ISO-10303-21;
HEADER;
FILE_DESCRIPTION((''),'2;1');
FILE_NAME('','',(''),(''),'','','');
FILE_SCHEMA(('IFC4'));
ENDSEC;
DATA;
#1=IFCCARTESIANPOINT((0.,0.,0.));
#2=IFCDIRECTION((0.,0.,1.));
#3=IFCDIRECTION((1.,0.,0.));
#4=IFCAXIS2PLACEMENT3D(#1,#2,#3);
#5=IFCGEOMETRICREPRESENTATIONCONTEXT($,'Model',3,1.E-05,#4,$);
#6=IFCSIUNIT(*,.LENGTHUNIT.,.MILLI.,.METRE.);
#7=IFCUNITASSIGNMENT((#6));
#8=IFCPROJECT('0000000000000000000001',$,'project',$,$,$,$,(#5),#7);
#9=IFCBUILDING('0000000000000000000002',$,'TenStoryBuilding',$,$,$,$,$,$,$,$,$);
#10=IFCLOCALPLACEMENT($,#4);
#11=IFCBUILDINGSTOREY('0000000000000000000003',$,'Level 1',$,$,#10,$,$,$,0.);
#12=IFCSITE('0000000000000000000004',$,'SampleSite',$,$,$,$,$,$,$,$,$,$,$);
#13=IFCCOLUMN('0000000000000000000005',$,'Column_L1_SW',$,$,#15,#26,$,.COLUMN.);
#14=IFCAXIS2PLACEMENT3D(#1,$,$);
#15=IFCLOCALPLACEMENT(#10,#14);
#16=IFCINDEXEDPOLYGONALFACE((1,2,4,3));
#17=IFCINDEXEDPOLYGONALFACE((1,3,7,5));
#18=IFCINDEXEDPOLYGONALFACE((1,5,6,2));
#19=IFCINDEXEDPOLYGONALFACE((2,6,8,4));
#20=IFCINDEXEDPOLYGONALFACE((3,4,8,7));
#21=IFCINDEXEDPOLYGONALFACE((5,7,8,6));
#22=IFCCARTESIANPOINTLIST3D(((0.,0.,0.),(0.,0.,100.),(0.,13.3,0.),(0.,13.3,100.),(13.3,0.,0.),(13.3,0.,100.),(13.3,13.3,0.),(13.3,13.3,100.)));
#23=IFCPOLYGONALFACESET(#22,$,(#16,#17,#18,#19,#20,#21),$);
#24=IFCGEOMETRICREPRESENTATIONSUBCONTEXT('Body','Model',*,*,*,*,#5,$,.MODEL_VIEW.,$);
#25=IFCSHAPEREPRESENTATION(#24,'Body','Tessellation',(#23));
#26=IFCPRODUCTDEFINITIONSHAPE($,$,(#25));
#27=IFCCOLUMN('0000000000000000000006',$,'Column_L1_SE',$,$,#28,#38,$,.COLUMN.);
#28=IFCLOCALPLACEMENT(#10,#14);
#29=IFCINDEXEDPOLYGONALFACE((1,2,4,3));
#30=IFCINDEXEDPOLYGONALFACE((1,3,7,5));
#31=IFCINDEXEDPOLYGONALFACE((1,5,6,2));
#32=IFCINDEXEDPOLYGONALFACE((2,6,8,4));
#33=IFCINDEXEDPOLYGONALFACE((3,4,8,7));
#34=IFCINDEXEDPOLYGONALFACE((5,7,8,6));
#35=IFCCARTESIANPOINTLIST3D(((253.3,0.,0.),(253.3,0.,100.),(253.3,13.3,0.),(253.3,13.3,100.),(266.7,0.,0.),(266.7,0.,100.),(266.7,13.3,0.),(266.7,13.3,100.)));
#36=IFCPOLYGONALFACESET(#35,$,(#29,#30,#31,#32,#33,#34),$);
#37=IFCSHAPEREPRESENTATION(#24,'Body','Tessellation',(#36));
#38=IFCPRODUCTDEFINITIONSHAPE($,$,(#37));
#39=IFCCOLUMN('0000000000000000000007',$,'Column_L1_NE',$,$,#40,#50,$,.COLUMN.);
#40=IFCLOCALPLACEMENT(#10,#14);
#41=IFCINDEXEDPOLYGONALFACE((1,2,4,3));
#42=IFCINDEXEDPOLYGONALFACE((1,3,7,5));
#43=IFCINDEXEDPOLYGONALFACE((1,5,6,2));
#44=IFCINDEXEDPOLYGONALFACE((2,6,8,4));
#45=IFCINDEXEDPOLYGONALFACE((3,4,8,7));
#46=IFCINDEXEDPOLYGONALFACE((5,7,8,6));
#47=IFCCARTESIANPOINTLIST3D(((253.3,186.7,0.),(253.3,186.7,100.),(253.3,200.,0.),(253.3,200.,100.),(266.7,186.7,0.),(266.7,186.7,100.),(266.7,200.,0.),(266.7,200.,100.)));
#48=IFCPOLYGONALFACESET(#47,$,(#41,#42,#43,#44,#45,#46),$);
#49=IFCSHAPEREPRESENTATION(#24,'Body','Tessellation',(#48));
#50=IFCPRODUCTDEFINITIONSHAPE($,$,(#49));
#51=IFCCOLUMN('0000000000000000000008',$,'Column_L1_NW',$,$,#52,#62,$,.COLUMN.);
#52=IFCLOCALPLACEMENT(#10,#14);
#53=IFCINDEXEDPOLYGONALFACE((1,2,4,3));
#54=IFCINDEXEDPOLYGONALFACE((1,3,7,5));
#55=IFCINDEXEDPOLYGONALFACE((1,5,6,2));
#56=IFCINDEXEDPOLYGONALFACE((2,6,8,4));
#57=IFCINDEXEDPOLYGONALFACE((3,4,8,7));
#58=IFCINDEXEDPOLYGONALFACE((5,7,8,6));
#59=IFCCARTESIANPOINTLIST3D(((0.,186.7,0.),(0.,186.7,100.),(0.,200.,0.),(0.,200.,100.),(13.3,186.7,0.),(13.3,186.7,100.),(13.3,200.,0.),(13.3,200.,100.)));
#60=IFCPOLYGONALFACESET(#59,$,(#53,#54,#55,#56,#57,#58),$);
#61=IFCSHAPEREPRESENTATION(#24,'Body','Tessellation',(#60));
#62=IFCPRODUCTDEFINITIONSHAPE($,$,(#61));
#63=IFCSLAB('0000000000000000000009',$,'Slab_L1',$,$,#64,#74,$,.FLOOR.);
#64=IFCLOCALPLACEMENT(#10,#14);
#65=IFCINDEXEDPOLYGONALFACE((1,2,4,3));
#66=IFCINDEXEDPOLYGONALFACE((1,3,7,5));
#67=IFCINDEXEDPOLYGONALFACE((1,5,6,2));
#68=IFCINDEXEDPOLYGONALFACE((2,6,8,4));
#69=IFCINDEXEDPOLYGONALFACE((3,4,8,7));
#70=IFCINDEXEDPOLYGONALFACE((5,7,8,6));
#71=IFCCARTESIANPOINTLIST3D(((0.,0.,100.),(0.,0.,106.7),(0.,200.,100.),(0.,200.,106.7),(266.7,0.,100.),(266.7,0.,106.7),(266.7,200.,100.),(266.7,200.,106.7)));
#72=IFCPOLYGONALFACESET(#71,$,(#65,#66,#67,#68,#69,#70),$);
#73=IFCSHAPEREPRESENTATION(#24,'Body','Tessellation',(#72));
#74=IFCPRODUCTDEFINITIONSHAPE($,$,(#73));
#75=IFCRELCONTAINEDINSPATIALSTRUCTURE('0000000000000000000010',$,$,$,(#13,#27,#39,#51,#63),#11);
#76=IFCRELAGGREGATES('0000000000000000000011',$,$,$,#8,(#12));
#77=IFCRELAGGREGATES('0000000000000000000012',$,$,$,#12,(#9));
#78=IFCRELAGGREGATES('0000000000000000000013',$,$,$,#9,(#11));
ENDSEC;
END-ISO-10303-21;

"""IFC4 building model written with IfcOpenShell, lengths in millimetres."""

from ifc_helpers import new_model, si_unit, frame, origin_with_axes, origin_2d, place, context, subcontext, project, spatial, indexed_curve, rectangle, outline, extrude, element, save


model = new_model("IFC4")

# Units and contexts
model_context = context("Model", 3, precision=1e-05, world=origin_with_axes())
body_context = subcontext(model_context, "Body", "Model", "MODEL_VIEW")
ifc_project = project(units=[si_unit("LENGTHUNIT", "METRE", prefix="MILLI")], contexts=[model_context])

# Site, building, storey
site = spatial("IfcSite", under=ifc_project, Name="SampleSite")
building = spatial("IfcBuilding", under=site, Name="TenStoryBuilding")
storey_placement = place(None, origin_with_axes())
storey = spatial("IfcBuildingStorey", under=building, at=storey_placement, Name="Level 1", Elevation=0.0)

# Columns
for number, where, z_axis, x_axis, name in (
    (1, (6.7, 6.7, 0.0), (0.0, 0.0, 1.0), (1.0, 0.0, 0.0), "Column_L1_SW"),
    (2, (260.0, 6.7, 0.0), (0.0, 0.0, 1.0), (1.0, 0.0, 0.0), "Column_L1_SE"),
    (3, (260.0, 193.3, 0.0), (0.0, 0.0, 1.0), (1.0, 0.0, 0.0), "Column_L1_NE"),
    (4, (6.7, 193.3, 0.0), (0.0, 0.0, 1.0), (1.0, 0.0, 0.0), "Column_L1_NW"),
):
    element("IfcColumn", number, at=place(storey_placement, frame(where, z_axis=z_axis, x_axis=x_axis)), inside=storey, Name=name, PredefinedType="COLUMN", context=body_context, shape_type="SweptSolid", body=[
        extrude(rectangle(XDim=13.3, YDim=13.3, at=origin_2d()), origin_with_axes(), (0.0, 0.0, 1.0), 100.0),
    ])

# Slab
slab_placement = place(storey_placement, frame((0.0, 0.0, 100.0), z_axis=(0.0, 0.0, 1.0), x_axis=(1.0, 0.0, 0.0)))
element("IfcSlab", 5, at=slab_placement, inside=storey, Name="Slab_L1", PredefinedType="FLOOR", context=body_context, shape_type="SweptSolid", body=[
    extrude(outline(indexed_curve([(0.0, 0.0), (266.7, 0.0), (266.7, 200.0), (0.0, 200.0), (0.0, 0.0)])), None, (0.0, 0.0, 1.0), 6.7),
])

save(model, "model.ifc")
